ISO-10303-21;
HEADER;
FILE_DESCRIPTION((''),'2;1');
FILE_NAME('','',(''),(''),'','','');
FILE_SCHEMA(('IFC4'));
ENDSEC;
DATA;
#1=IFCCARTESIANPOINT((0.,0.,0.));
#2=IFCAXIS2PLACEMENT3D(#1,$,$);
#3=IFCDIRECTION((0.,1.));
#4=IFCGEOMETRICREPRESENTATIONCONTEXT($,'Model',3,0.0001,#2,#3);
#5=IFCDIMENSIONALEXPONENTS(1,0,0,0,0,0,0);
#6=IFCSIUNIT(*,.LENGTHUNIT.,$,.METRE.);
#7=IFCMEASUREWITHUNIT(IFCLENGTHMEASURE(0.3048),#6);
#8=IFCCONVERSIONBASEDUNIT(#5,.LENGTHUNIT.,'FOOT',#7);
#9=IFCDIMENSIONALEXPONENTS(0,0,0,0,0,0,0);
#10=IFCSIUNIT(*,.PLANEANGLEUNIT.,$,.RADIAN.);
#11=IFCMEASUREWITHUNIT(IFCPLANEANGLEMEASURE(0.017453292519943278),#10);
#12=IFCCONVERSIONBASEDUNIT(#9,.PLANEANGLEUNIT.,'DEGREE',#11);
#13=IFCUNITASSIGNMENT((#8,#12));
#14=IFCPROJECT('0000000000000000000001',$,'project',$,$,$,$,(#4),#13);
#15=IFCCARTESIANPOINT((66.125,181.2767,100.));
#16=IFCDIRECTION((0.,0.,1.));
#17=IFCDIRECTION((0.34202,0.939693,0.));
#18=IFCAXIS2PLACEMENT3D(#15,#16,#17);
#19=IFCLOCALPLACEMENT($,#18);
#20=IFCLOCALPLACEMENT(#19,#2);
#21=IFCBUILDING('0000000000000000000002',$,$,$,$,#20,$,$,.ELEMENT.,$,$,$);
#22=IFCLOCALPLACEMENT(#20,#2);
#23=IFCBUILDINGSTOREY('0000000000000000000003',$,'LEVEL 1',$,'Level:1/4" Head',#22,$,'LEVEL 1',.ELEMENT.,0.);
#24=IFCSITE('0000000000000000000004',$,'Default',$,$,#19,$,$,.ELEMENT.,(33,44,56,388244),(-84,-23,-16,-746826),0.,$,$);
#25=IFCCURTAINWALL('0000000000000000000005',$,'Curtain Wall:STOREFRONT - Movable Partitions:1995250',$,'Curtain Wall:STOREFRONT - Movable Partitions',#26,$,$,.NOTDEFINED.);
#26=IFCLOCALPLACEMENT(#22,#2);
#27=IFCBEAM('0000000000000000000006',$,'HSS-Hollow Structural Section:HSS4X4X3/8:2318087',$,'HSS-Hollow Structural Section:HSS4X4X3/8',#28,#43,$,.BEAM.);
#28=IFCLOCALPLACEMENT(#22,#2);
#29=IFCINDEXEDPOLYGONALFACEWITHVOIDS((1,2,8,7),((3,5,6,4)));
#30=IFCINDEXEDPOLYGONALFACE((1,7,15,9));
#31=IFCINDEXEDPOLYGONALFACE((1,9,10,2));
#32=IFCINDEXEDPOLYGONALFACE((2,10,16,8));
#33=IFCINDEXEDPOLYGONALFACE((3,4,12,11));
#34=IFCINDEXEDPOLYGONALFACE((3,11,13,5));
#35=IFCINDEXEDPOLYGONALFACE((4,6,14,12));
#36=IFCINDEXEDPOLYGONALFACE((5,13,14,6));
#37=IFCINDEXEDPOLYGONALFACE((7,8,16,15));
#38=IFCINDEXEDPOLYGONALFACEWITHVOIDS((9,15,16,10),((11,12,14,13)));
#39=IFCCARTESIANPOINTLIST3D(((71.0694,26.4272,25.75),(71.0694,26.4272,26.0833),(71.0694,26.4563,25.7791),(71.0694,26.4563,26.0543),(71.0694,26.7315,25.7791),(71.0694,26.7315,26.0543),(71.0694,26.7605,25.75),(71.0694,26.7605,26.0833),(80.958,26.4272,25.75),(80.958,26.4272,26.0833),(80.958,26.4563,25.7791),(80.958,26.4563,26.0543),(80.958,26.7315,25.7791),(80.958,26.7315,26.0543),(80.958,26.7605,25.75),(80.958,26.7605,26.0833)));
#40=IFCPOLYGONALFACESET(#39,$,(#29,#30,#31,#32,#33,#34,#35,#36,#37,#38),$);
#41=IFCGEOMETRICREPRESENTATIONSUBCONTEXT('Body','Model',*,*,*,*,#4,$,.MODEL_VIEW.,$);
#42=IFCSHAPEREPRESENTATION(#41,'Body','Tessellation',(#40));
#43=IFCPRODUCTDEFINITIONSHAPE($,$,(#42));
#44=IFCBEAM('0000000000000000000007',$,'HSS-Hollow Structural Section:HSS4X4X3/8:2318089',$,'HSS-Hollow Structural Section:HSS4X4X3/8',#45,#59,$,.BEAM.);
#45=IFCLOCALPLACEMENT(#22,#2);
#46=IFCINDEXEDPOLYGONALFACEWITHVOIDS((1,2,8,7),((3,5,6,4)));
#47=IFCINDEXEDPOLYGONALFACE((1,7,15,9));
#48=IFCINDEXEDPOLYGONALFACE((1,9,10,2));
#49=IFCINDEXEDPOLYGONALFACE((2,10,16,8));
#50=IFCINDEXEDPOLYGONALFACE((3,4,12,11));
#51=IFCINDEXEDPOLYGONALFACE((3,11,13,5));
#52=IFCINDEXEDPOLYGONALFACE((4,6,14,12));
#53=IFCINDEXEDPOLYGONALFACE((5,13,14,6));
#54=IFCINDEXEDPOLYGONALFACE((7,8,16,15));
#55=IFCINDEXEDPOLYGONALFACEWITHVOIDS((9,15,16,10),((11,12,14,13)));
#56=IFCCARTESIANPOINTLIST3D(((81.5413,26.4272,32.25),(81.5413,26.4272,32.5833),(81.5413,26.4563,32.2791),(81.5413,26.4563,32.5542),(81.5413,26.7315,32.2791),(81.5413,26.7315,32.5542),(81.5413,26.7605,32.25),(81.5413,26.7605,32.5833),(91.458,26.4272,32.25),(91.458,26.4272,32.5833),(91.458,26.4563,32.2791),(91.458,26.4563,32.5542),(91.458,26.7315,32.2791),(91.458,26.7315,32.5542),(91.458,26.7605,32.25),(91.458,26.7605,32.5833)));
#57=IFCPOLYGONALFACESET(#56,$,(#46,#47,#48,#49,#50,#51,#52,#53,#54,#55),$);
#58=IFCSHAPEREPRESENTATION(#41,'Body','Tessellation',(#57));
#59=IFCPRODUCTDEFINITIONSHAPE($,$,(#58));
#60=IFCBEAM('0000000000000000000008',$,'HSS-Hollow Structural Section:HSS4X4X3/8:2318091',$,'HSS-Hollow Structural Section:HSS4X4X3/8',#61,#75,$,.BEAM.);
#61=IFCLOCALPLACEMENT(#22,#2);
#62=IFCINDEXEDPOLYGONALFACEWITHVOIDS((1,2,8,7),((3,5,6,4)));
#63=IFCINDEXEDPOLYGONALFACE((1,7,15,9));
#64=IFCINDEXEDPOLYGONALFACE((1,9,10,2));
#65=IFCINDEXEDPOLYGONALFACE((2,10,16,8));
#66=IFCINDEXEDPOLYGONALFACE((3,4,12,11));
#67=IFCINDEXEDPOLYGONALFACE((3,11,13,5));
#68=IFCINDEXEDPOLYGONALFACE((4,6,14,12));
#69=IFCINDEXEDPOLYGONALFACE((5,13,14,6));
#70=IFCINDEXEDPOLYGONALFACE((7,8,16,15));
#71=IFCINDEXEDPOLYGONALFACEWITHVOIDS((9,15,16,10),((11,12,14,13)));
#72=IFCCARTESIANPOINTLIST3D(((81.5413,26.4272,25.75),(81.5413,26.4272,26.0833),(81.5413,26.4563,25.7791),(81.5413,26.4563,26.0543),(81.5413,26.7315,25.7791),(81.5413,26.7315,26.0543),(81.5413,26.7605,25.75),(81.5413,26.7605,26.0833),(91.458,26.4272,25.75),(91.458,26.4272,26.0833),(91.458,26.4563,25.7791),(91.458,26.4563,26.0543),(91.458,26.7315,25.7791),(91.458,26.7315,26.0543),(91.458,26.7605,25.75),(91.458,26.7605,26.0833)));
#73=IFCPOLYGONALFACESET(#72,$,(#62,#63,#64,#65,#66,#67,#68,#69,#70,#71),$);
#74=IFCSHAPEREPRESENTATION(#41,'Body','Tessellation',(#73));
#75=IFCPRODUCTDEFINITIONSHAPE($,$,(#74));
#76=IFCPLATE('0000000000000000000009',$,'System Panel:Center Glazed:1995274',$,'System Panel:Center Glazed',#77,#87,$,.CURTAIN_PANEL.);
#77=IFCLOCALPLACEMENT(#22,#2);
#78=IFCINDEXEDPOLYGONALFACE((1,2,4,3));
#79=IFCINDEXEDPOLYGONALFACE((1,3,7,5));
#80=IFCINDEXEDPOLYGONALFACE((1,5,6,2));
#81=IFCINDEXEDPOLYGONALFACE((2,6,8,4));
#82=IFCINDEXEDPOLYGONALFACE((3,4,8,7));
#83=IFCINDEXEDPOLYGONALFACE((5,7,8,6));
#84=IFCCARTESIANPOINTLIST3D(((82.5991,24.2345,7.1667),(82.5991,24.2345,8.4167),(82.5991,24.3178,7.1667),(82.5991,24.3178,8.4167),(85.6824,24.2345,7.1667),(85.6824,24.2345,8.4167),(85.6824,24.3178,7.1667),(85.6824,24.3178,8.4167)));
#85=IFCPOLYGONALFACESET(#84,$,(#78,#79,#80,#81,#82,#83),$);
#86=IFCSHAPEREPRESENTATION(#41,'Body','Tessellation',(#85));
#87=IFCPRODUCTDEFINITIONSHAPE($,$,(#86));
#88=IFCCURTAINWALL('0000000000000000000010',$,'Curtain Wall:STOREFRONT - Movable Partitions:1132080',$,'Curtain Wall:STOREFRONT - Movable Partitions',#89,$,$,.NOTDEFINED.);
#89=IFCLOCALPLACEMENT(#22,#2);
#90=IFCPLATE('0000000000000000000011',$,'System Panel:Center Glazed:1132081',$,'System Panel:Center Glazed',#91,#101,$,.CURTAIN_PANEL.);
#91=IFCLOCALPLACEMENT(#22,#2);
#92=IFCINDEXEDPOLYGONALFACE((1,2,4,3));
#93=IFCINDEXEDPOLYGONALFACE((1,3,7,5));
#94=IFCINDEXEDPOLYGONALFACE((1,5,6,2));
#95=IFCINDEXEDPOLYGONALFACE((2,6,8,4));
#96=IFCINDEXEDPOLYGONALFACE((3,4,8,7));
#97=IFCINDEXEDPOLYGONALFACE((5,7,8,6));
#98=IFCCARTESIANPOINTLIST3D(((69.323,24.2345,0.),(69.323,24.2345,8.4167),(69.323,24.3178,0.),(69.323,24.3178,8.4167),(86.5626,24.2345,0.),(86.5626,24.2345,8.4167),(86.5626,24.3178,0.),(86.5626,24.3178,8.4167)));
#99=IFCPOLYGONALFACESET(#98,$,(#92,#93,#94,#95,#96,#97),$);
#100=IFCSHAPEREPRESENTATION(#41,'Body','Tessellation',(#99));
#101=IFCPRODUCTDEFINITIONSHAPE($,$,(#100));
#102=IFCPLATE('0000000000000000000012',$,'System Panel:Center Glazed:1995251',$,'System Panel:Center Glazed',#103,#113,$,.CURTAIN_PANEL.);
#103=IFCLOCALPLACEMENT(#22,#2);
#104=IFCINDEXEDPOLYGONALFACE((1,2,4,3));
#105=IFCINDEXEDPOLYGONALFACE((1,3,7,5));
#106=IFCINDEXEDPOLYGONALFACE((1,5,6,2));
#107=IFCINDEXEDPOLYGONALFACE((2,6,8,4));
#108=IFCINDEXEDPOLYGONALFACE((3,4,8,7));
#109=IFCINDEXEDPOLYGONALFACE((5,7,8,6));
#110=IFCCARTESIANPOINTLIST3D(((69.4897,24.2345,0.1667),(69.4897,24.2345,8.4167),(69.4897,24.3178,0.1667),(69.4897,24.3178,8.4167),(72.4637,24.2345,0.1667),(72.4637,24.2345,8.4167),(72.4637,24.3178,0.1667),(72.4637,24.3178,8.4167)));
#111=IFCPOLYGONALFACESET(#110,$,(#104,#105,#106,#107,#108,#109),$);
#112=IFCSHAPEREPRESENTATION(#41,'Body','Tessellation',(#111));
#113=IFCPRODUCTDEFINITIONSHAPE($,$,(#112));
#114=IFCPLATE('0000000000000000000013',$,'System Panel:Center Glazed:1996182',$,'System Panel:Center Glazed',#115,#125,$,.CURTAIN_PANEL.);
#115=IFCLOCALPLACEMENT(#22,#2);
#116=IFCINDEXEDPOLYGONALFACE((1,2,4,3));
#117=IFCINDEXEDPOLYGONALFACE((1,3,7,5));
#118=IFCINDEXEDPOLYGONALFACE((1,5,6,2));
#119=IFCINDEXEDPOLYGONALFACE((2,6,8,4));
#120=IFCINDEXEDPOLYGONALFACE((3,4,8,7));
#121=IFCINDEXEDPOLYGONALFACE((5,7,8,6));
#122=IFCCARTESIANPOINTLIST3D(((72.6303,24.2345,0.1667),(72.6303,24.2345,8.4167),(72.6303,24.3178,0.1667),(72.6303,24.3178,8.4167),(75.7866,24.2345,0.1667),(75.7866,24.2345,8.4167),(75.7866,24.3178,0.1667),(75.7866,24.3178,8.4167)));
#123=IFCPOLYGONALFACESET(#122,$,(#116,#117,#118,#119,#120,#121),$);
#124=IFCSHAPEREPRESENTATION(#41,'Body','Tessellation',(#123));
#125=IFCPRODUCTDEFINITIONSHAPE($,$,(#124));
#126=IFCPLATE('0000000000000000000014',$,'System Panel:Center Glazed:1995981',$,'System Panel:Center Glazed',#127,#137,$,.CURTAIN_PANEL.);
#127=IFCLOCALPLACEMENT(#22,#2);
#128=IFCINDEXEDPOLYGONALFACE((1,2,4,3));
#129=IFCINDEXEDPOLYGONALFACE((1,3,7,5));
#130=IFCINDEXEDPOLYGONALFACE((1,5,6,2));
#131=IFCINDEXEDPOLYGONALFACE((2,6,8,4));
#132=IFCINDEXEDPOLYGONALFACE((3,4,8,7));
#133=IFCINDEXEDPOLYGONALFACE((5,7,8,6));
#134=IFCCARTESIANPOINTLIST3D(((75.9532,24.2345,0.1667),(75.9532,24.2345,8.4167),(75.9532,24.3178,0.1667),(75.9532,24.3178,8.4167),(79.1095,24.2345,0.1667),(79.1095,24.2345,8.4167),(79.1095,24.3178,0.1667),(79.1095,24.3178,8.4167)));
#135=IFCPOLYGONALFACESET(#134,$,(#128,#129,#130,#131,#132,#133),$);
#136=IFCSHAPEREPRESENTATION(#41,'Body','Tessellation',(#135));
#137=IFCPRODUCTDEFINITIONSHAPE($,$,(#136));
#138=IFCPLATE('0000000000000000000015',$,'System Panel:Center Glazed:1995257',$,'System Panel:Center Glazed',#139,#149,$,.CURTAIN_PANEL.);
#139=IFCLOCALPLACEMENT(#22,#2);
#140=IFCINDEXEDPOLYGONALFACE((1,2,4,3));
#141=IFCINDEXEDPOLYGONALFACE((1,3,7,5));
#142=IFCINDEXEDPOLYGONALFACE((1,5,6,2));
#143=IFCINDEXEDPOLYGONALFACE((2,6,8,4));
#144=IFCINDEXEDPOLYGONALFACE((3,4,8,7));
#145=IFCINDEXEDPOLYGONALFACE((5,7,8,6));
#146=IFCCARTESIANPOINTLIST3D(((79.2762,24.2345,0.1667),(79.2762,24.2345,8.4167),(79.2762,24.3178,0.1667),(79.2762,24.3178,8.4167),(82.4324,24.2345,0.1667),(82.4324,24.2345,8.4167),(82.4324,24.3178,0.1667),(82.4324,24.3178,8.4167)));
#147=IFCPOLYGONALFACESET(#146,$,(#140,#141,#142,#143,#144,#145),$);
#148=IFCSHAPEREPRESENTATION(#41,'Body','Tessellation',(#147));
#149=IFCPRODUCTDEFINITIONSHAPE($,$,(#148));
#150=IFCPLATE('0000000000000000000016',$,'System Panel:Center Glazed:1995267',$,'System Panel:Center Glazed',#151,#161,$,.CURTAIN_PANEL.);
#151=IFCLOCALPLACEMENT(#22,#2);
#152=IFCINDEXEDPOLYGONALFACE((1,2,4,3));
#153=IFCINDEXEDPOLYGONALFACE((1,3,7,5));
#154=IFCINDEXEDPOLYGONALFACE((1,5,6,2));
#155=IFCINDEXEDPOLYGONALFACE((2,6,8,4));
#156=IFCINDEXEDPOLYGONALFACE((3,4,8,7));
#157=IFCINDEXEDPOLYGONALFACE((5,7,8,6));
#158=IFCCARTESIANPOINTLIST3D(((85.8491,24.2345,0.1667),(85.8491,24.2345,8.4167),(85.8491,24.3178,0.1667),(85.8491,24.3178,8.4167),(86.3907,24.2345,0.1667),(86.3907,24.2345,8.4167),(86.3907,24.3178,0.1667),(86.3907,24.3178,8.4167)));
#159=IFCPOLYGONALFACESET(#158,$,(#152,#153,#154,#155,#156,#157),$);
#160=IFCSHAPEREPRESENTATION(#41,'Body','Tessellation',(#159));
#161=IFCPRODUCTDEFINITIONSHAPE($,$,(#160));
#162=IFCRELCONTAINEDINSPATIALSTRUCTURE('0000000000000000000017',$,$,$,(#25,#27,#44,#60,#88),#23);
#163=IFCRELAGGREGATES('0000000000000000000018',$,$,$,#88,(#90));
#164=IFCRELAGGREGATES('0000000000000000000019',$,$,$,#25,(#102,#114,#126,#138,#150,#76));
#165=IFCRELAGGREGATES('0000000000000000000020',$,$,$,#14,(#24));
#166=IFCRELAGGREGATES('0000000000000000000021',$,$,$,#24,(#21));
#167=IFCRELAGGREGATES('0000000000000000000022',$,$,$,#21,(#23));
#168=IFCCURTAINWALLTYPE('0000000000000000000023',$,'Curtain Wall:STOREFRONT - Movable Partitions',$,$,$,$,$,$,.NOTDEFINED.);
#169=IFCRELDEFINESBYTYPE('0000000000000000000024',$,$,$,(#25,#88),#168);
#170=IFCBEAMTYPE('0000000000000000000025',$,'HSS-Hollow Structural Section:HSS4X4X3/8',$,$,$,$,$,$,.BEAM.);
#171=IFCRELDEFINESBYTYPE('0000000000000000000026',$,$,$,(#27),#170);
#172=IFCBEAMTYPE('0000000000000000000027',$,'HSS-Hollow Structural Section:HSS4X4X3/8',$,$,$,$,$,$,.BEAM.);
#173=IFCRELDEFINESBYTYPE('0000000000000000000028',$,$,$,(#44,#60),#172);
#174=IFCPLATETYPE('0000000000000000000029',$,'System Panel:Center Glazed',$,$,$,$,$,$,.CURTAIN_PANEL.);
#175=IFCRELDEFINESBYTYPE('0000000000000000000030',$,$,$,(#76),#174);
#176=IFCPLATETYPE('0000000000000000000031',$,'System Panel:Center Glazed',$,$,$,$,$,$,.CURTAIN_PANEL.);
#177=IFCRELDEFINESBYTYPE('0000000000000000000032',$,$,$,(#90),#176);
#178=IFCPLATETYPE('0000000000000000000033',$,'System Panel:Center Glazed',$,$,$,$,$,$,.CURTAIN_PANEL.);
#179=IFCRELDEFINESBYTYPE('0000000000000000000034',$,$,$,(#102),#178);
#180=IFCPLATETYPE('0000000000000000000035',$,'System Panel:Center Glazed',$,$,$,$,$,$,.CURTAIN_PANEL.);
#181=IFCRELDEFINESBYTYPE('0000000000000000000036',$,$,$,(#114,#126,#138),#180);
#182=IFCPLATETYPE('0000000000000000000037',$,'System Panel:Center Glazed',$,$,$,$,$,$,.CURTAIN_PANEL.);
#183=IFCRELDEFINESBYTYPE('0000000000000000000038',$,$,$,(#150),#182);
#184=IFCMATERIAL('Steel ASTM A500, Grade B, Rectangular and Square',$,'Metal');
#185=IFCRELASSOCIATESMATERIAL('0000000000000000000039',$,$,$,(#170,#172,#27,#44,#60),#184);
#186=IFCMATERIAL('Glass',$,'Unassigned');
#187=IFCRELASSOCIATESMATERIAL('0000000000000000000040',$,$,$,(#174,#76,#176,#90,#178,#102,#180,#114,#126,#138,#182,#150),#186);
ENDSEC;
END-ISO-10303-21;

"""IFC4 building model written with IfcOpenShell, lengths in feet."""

from ifc_helpers import new_model, entity, si_unit, converted_unit, direction, frame, frame_2d, origin, origin_2d_with_axis, place, context, subcontext, project, spatial, rectangle, extrude, boolean, source, transform, mapped, material, material_profile, profile_set, type_object, type_shapes, element, aggregate, save


model = new_model("IFC4")

# Units and contexts
model_context = context("Model", 3, precision=0.0001, world=origin(), true_north=direction((0.0, 1.0)))
body_context = subcontext(model_context, "Body", "Model", "MODEL_VIEW")
ifc_project = project(units=[converted_unit("LENGTHUNIT", "FOOT", entity("IfcLengthMeasure", 0.3048), si_unit("LENGTHUNIT", "METRE"), dimensions=[1, 0, 0, 0, 0, 0, 0]), converted_unit("PLANEANGLEUNIT", "DEGREE", entity("IfcPlaneAngleMeasure", 0.017453292519943278), si_unit("PLANEANGLEUNIT", "RADIAN"), dimensions=[0, 0, 0, 0, 0, 0, 0])], contexts=[model_context])

# Site, building, storey
site_placement = place(None, frame((66.125, 181.2767, 100.0), z_axis=(0.0, 0.0, 1.0), x_axis=(0.34202, 0.939693, 0.0)))
site = spatial("IfcSite", under=ifc_project, at=site_placement, Name="Default", CompositionType="ELEMENT", RefLatitude=(33, 44, 56, 388244), RefLongitude=(-84, -23, -16, -746826), RefElevation=0.0)
building_placement = place(site_placement, origin())
building = spatial("IfcBuilding", under=site, at=building_placement, CompositionType="ELEMENT")
storey_placement = place(building_placement, origin())
storey = spatial("IfcBuildingStorey", under=building, at=storey_placement, Name="LEVEL 1", ObjectType="Level:1/4\" Head", LongName="LEVEL 1", CompositionType="ELEMENT", Elevation=0.0)

# Curtain wall
curtain_wall_type = type_object("IfcCurtainWallType", Name="Curtain Wall:STOREFRONT - Movable Partitions", PredefinedType="NOTDEFINED")
curtain_wall_1_placement = place(storey_placement, origin())
curtain_wall_1 = element("IfcCurtainWall", 1, at=curtain_wall_1_placement, inside=storey, type_object=curtain_wall_type, Name="Curtain Wall:STOREFRONT - Movable Partitions:1995250", ObjectType="Curtain Wall:STOREFRONT - Movable Partitions", PredefinedType="NOTDEFINED")

# Beams
ifc_material_1 = material(Name="Steel ASTM A500, Grade B, Rectangular and Square", Category="Metal")
ifc_material_profile_1 = material_profile(ifc_material_1, rectangle(XDim=0.3333, YDim=0.3333, at=origin_2d_with_axis()), Name="HSS4X4X3/8")
ifc_profile_set_1 = profile_set([ifc_material_profile_1], Name="HSS4X4X3/8")
beam_type_1 = type_object("IfcBeamType", Name="HSS-Hollow Structural Section:HSS4X4X3/8", PredefinedType="BEAM", material=ifc_profile_set_1)
shared_shape_1 = source(origin(), body_context, "Body", "SweptSolid", [
    boolean("DIFFERENCE", extrude(rectangle(XDim=0.3333, YDim=0.3333, at=origin_2d_with_axis()), frame((-4.9443, 0.0, 0.0), z_axis=(1.0, 0.0, 0.0), x_axis=(0.0, 0.0, -1.0)), (0.0, 0.0, 1.0), 9.8886), extrude(rectangle(XDim=0.2752, YDim=0.2752, at=frame_2d((0.0, 0.0), x_axis=(0.0, 1.0))), frame((4.9443, 0.0, 0.0), z_axis=(-1.0, 0.0, 0.0), x_axis=(0.0, 1.0, 0.0)), (0.0, 0.0, 1.0), 9.8886)),
])
type_shapes(beam_type_1, [shared_shape_1])
for number, where, name in (
    (2, (76.0137, 26.5939, 25.9167), "HSS-Hollow Structural Section:HSS4X4X3/8:2318087"),
):
    element("IfcBeam", number, at=place(storey_placement, frame(where)), inside=storey, type_object=beam_type_1, material=ifc_material_1, Name=name, ObjectType="HSS-Hollow Structural Section:HSS4X4X3/8", PredefinedType="BEAM", context=body_context, shape_type="MappedRepresentation", body=[
        mapped(shared_shape_1, transform((0.0, 0.0, 0.0), scale=1.0)),
    ])
beam_type_2 = type_object("IfcBeamType", Name="HSS-Hollow Structural Section:HSS4X4X3/8", PredefinedType="BEAM", material=ifc_profile_set_1)
shared_shape_2 = source(origin(), body_context, "Body", "SweptSolid", [
    boolean("DIFFERENCE", extrude(rectangle(XDim=0.3333, YDim=0.3333, at=origin_2d_with_axis()), frame((-4.9167, 0.0, 0.0), z_axis=(1.0, 0.0, 0.0), x_axis=(0.0, 0.0, -1.0)), (0.0, 0.0, 1.0), 9.9167), extrude(rectangle(XDim=0.2752, YDim=0.2752, at=frame_2d((0.0, 0.0), x_axis=(0.0, 1.0))), frame((-4.9167, 0.0, 0.0), z_axis=(1.0, 0.0, 0.0), x_axis=(0.0, -1.0, 0.0)), (0.0, 0.0, 1.0), 9.9167)),
])
type_shapes(beam_type_2, [shared_shape_2])
for number, where, z_axis, x_axis, name in (
    (3, (86.5413, 26.5939, 32.4167), (0.0, 0.0, 1.0), (-1.0, 0.0, 0.0), "HSS-Hollow Structural Section:HSS4X4X3/8:2318089"),
    (4, (86.5413, 26.5939, 25.9167), (0.0, 0.0, 1.0), (-1.0, 0.0, 0.0), "HSS-Hollow Structural Section:HSS4X4X3/8:2318091"),
):
    element("IfcBeam", number, at=place(storey_placement, frame(where, z_axis=z_axis, x_axis=x_axis)), inside=storey, type_object=beam_type_2, material=ifc_material_1, Name=name, ObjectType="HSS-Hollow Structural Section:HSS4X4X3/8", PredefinedType="BEAM", context=body_context, shape_type="MappedRepresentation", body=[
        mapped(shared_shape_2, transform((0.0, 0.0, 0.0), scale=1.0)),
    ])

# Plate
ifc_material_2 = material(Name="Glass", Category="Unassigned")
plate_type_1 = type_object("IfcPlateType", Name="System Panel:Center Glazed", PredefinedType="CURTAIN_PANEL", material=ifc_material_2)
shared_shape_3 = source(origin(), body_context, "Body", "SweptSolid", [
    extrude(rectangle(XDim=0.0833, YDim=3.0833, at=origin_2d_with_axis()), frame((0.0, 0.0, 0.0), z_axis=(0.0, 0.0, 1.0), x_axis=(0.0, 1.0, 0.0)), (0.0, 0.0, 1.0), 1.25),
])
type_shapes(plate_type_1, [shared_shape_3])
plate_1_placement = place(curtain_wall_1_placement, frame((84.1407, 24.2762, 7.1667)))
plate_1 = element("IfcPlate", 5, at=plate_1_placement, type_object=plate_type_1, material=ifc_material_2, Name="System Panel:Center Glazed:1995274", ObjectType="System Panel:Center Glazed", PredefinedType="CURTAIN_PANEL", context=body_context, shape_type="MappedRepresentation", body=[
    mapped(shared_shape_3, transform((0.0, 0.0, 0.0), scale=1.0)),
])

# Curtain wall, plate
curtain_wall_2_placement = place(storey_placement, origin())
curtain_wall_2 = element("IfcCurtainWall", 6, at=curtain_wall_2_placement, inside=storey, type_object=curtain_wall_type, Name="Curtain Wall:STOREFRONT - Movable Partitions:1132080", ObjectType="Curtain Wall:STOREFRONT - Movable Partitions", PredefinedType="NOTDEFINED")
plate_type_2 = type_object("IfcPlateType", Name="System Panel:Center Glazed", PredefinedType="CURTAIN_PANEL", material=ifc_material_2)
shared_shape_4 = source(origin(), body_context, "Body", "SweptSolid", [
    extrude(rectangle(XDim=0.0833, YDim=17.2396, at=origin_2d_with_axis()), frame((0.0, 0.0, 0.0), z_axis=(0.0, 0.0, 1.0), x_axis=(0.0, 1.0, 0.0)), (0.0, 0.0, 1.0), 8.4167),
])
type_shapes(plate_type_2, [shared_shape_4])
plate_2_placement = place(curtain_wall_2_placement, frame((77.9428, 24.2762, 0.0)))
plate_2 = element("IfcPlate", 7, at=plate_2_placement, type_object=plate_type_2, material=ifc_material_2, Name="System Panel:Center Glazed:1132081", ObjectType="System Panel:Center Glazed", PredefinedType="CURTAIN_PANEL", context=body_context, shape_type="MappedRepresentation", body=[
    mapped(shared_shape_4, transform((0.0, 0.0, 0.0), scale=1.0)),
])
aggregate(curtain_wall_2, [plate_2])

# Plates
plate_type_3 = type_object("IfcPlateType", Name="System Panel:Center Glazed", PredefinedType="CURTAIN_PANEL", material=ifc_material_2)
shared_shape_5 = source(origin(), body_context, "Body", "SweptSolid", [
    extrude(rectangle(XDim=8.25, YDim=2.974, at=frame_2d((-0.9306, 0.0), x_axis=(1.0, 0.0))), frame((0.0, -0.0417, 5.0556), z_axis=(0.0, 1.0, 0.0), x_axis=(0.0, 0.0, 1.0)), (0.0, 0.0, 1.0), 0.0833),
])
type_shapes(plate_type_3, [shared_shape_5])
plate_3_placement = place(curtain_wall_1_placement, frame((70.9767, 24.2762, 0.1667)))
plate_3 = element("IfcPlate", 8, at=plate_3_placement, type_object=plate_type_3, material=ifc_material_2, Name="System Panel:Center Glazed:1995251", ObjectType="System Panel:Center Glazed", PredefinedType="CURTAIN_PANEL", context=body_context, shape_type="MappedRepresentation", body=[
    mapped(shared_shape_5, transform((0.0, 0.0, 0.0), scale=1.0)),
])
plate_type_4 = type_object("IfcPlateType", Name="System Panel:Center Glazed", PredefinedType="CURTAIN_PANEL", material=ifc_material_2)
shared_shape_6 = source(origin(), body_context, "Body", "SweptSolid", [
    extrude(rectangle(XDim=8.25, YDim=3.1563, at=frame_2d((-0.9306, 0.0), x_axis=(1.0, 0.0))), frame((0.0, -0.0417, 5.0556), z_axis=(0.0, 1.0, 0.0), x_axis=(0.0, 0.0, 1.0)), (0.0, 0.0, 1.0), 0.0833),
])
type_shapes(plate_type_4, [shared_shape_6])
plate_4_placement = place(curtain_wall_1_placement, frame((74.2084, 24.2762, 0.1667)))
plate_4 = element("IfcPlate", 9, at=plate_4_placement, type_object=plate_type_4, material=ifc_material_2, Name="System Panel:Center Glazed:1996182", ObjectType="System Panel:Center Glazed", PredefinedType="CURTAIN_PANEL", context=body_context, shape_type="MappedRepresentation", body=[
    mapped(shared_shape_6, transform((0.0, 0.0, 0.0), scale=1.0)),
])
plate_5_placement = place(curtain_wall_1_placement, frame((77.5314, 24.2762, 0.1667)))
plate_5 = element("IfcPlate", 10, at=plate_5_placement, type_object=plate_type_4, material=ifc_material_2, Name="System Panel:Center Glazed:1995981", ObjectType="System Panel:Center Glazed", PredefinedType="CURTAIN_PANEL", context=body_context, shape_type="MappedRepresentation", body=[
    mapped(shared_shape_6, transform((0.0, 0.0, 0.0), scale=1.0)),
])
plate_6_placement = place(curtain_wall_1_placement, frame((80.8543, 24.2762, 0.1667)))
plate_6 = element("IfcPlate", 11, at=plate_6_placement, type_object=plate_type_4, material=ifc_material_2, Name="System Panel:Center Glazed:1995257", ObjectType="System Panel:Center Glazed", PredefinedType="CURTAIN_PANEL", context=body_context, shape_type="MappedRepresentation", body=[
    mapped(shared_shape_6, transform((0.0, 0.0, 0.0), scale=1.0)),
])
plate_type_5 = type_object("IfcPlateType", Name="System Panel:Center Glazed", PredefinedType="CURTAIN_PANEL", material=ifc_material_2)
shared_shape_7 = source(origin(), body_context, "Body", "SweptSolid", [
    extrude(rectangle(XDim=8.25, YDim=0.5417, at=frame_2d((-0.9306, 0.0), x_axis=(1.0, 0.0))), frame((0.0, -0.0417, 5.0556), z_axis=(0.0, 1.0, 0.0), x_axis=(0.0, 0.0, 1.0)), (0.0, 0.0, 1.0), 0.0833),
])
type_shapes(plate_type_5, [shared_shape_7])
plate_7_placement = place(curtain_wall_1_placement, frame((86.1199, 24.2762, 0.1667)))
plate_7 = element("IfcPlate", 12, at=plate_7_placement, type_object=plate_type_5, material=ifc_material_2, Name="System Panel:Center Glazed:1995267", ObjectType="System Panel:Center Glazed", PredefinedType="CURTAIN_PANEL", context=body_context, shape_type="MappedRepresentation", body=[
    mapped(shared_shape_7, transform((0.0, 0.0, 0.0), scale=1.0)),
])

aggregate(curtain_wall_1, [plate_3, plate_4, plate_5, plate_6, plate_7, plate_1])

save(model, "model.ifc")
